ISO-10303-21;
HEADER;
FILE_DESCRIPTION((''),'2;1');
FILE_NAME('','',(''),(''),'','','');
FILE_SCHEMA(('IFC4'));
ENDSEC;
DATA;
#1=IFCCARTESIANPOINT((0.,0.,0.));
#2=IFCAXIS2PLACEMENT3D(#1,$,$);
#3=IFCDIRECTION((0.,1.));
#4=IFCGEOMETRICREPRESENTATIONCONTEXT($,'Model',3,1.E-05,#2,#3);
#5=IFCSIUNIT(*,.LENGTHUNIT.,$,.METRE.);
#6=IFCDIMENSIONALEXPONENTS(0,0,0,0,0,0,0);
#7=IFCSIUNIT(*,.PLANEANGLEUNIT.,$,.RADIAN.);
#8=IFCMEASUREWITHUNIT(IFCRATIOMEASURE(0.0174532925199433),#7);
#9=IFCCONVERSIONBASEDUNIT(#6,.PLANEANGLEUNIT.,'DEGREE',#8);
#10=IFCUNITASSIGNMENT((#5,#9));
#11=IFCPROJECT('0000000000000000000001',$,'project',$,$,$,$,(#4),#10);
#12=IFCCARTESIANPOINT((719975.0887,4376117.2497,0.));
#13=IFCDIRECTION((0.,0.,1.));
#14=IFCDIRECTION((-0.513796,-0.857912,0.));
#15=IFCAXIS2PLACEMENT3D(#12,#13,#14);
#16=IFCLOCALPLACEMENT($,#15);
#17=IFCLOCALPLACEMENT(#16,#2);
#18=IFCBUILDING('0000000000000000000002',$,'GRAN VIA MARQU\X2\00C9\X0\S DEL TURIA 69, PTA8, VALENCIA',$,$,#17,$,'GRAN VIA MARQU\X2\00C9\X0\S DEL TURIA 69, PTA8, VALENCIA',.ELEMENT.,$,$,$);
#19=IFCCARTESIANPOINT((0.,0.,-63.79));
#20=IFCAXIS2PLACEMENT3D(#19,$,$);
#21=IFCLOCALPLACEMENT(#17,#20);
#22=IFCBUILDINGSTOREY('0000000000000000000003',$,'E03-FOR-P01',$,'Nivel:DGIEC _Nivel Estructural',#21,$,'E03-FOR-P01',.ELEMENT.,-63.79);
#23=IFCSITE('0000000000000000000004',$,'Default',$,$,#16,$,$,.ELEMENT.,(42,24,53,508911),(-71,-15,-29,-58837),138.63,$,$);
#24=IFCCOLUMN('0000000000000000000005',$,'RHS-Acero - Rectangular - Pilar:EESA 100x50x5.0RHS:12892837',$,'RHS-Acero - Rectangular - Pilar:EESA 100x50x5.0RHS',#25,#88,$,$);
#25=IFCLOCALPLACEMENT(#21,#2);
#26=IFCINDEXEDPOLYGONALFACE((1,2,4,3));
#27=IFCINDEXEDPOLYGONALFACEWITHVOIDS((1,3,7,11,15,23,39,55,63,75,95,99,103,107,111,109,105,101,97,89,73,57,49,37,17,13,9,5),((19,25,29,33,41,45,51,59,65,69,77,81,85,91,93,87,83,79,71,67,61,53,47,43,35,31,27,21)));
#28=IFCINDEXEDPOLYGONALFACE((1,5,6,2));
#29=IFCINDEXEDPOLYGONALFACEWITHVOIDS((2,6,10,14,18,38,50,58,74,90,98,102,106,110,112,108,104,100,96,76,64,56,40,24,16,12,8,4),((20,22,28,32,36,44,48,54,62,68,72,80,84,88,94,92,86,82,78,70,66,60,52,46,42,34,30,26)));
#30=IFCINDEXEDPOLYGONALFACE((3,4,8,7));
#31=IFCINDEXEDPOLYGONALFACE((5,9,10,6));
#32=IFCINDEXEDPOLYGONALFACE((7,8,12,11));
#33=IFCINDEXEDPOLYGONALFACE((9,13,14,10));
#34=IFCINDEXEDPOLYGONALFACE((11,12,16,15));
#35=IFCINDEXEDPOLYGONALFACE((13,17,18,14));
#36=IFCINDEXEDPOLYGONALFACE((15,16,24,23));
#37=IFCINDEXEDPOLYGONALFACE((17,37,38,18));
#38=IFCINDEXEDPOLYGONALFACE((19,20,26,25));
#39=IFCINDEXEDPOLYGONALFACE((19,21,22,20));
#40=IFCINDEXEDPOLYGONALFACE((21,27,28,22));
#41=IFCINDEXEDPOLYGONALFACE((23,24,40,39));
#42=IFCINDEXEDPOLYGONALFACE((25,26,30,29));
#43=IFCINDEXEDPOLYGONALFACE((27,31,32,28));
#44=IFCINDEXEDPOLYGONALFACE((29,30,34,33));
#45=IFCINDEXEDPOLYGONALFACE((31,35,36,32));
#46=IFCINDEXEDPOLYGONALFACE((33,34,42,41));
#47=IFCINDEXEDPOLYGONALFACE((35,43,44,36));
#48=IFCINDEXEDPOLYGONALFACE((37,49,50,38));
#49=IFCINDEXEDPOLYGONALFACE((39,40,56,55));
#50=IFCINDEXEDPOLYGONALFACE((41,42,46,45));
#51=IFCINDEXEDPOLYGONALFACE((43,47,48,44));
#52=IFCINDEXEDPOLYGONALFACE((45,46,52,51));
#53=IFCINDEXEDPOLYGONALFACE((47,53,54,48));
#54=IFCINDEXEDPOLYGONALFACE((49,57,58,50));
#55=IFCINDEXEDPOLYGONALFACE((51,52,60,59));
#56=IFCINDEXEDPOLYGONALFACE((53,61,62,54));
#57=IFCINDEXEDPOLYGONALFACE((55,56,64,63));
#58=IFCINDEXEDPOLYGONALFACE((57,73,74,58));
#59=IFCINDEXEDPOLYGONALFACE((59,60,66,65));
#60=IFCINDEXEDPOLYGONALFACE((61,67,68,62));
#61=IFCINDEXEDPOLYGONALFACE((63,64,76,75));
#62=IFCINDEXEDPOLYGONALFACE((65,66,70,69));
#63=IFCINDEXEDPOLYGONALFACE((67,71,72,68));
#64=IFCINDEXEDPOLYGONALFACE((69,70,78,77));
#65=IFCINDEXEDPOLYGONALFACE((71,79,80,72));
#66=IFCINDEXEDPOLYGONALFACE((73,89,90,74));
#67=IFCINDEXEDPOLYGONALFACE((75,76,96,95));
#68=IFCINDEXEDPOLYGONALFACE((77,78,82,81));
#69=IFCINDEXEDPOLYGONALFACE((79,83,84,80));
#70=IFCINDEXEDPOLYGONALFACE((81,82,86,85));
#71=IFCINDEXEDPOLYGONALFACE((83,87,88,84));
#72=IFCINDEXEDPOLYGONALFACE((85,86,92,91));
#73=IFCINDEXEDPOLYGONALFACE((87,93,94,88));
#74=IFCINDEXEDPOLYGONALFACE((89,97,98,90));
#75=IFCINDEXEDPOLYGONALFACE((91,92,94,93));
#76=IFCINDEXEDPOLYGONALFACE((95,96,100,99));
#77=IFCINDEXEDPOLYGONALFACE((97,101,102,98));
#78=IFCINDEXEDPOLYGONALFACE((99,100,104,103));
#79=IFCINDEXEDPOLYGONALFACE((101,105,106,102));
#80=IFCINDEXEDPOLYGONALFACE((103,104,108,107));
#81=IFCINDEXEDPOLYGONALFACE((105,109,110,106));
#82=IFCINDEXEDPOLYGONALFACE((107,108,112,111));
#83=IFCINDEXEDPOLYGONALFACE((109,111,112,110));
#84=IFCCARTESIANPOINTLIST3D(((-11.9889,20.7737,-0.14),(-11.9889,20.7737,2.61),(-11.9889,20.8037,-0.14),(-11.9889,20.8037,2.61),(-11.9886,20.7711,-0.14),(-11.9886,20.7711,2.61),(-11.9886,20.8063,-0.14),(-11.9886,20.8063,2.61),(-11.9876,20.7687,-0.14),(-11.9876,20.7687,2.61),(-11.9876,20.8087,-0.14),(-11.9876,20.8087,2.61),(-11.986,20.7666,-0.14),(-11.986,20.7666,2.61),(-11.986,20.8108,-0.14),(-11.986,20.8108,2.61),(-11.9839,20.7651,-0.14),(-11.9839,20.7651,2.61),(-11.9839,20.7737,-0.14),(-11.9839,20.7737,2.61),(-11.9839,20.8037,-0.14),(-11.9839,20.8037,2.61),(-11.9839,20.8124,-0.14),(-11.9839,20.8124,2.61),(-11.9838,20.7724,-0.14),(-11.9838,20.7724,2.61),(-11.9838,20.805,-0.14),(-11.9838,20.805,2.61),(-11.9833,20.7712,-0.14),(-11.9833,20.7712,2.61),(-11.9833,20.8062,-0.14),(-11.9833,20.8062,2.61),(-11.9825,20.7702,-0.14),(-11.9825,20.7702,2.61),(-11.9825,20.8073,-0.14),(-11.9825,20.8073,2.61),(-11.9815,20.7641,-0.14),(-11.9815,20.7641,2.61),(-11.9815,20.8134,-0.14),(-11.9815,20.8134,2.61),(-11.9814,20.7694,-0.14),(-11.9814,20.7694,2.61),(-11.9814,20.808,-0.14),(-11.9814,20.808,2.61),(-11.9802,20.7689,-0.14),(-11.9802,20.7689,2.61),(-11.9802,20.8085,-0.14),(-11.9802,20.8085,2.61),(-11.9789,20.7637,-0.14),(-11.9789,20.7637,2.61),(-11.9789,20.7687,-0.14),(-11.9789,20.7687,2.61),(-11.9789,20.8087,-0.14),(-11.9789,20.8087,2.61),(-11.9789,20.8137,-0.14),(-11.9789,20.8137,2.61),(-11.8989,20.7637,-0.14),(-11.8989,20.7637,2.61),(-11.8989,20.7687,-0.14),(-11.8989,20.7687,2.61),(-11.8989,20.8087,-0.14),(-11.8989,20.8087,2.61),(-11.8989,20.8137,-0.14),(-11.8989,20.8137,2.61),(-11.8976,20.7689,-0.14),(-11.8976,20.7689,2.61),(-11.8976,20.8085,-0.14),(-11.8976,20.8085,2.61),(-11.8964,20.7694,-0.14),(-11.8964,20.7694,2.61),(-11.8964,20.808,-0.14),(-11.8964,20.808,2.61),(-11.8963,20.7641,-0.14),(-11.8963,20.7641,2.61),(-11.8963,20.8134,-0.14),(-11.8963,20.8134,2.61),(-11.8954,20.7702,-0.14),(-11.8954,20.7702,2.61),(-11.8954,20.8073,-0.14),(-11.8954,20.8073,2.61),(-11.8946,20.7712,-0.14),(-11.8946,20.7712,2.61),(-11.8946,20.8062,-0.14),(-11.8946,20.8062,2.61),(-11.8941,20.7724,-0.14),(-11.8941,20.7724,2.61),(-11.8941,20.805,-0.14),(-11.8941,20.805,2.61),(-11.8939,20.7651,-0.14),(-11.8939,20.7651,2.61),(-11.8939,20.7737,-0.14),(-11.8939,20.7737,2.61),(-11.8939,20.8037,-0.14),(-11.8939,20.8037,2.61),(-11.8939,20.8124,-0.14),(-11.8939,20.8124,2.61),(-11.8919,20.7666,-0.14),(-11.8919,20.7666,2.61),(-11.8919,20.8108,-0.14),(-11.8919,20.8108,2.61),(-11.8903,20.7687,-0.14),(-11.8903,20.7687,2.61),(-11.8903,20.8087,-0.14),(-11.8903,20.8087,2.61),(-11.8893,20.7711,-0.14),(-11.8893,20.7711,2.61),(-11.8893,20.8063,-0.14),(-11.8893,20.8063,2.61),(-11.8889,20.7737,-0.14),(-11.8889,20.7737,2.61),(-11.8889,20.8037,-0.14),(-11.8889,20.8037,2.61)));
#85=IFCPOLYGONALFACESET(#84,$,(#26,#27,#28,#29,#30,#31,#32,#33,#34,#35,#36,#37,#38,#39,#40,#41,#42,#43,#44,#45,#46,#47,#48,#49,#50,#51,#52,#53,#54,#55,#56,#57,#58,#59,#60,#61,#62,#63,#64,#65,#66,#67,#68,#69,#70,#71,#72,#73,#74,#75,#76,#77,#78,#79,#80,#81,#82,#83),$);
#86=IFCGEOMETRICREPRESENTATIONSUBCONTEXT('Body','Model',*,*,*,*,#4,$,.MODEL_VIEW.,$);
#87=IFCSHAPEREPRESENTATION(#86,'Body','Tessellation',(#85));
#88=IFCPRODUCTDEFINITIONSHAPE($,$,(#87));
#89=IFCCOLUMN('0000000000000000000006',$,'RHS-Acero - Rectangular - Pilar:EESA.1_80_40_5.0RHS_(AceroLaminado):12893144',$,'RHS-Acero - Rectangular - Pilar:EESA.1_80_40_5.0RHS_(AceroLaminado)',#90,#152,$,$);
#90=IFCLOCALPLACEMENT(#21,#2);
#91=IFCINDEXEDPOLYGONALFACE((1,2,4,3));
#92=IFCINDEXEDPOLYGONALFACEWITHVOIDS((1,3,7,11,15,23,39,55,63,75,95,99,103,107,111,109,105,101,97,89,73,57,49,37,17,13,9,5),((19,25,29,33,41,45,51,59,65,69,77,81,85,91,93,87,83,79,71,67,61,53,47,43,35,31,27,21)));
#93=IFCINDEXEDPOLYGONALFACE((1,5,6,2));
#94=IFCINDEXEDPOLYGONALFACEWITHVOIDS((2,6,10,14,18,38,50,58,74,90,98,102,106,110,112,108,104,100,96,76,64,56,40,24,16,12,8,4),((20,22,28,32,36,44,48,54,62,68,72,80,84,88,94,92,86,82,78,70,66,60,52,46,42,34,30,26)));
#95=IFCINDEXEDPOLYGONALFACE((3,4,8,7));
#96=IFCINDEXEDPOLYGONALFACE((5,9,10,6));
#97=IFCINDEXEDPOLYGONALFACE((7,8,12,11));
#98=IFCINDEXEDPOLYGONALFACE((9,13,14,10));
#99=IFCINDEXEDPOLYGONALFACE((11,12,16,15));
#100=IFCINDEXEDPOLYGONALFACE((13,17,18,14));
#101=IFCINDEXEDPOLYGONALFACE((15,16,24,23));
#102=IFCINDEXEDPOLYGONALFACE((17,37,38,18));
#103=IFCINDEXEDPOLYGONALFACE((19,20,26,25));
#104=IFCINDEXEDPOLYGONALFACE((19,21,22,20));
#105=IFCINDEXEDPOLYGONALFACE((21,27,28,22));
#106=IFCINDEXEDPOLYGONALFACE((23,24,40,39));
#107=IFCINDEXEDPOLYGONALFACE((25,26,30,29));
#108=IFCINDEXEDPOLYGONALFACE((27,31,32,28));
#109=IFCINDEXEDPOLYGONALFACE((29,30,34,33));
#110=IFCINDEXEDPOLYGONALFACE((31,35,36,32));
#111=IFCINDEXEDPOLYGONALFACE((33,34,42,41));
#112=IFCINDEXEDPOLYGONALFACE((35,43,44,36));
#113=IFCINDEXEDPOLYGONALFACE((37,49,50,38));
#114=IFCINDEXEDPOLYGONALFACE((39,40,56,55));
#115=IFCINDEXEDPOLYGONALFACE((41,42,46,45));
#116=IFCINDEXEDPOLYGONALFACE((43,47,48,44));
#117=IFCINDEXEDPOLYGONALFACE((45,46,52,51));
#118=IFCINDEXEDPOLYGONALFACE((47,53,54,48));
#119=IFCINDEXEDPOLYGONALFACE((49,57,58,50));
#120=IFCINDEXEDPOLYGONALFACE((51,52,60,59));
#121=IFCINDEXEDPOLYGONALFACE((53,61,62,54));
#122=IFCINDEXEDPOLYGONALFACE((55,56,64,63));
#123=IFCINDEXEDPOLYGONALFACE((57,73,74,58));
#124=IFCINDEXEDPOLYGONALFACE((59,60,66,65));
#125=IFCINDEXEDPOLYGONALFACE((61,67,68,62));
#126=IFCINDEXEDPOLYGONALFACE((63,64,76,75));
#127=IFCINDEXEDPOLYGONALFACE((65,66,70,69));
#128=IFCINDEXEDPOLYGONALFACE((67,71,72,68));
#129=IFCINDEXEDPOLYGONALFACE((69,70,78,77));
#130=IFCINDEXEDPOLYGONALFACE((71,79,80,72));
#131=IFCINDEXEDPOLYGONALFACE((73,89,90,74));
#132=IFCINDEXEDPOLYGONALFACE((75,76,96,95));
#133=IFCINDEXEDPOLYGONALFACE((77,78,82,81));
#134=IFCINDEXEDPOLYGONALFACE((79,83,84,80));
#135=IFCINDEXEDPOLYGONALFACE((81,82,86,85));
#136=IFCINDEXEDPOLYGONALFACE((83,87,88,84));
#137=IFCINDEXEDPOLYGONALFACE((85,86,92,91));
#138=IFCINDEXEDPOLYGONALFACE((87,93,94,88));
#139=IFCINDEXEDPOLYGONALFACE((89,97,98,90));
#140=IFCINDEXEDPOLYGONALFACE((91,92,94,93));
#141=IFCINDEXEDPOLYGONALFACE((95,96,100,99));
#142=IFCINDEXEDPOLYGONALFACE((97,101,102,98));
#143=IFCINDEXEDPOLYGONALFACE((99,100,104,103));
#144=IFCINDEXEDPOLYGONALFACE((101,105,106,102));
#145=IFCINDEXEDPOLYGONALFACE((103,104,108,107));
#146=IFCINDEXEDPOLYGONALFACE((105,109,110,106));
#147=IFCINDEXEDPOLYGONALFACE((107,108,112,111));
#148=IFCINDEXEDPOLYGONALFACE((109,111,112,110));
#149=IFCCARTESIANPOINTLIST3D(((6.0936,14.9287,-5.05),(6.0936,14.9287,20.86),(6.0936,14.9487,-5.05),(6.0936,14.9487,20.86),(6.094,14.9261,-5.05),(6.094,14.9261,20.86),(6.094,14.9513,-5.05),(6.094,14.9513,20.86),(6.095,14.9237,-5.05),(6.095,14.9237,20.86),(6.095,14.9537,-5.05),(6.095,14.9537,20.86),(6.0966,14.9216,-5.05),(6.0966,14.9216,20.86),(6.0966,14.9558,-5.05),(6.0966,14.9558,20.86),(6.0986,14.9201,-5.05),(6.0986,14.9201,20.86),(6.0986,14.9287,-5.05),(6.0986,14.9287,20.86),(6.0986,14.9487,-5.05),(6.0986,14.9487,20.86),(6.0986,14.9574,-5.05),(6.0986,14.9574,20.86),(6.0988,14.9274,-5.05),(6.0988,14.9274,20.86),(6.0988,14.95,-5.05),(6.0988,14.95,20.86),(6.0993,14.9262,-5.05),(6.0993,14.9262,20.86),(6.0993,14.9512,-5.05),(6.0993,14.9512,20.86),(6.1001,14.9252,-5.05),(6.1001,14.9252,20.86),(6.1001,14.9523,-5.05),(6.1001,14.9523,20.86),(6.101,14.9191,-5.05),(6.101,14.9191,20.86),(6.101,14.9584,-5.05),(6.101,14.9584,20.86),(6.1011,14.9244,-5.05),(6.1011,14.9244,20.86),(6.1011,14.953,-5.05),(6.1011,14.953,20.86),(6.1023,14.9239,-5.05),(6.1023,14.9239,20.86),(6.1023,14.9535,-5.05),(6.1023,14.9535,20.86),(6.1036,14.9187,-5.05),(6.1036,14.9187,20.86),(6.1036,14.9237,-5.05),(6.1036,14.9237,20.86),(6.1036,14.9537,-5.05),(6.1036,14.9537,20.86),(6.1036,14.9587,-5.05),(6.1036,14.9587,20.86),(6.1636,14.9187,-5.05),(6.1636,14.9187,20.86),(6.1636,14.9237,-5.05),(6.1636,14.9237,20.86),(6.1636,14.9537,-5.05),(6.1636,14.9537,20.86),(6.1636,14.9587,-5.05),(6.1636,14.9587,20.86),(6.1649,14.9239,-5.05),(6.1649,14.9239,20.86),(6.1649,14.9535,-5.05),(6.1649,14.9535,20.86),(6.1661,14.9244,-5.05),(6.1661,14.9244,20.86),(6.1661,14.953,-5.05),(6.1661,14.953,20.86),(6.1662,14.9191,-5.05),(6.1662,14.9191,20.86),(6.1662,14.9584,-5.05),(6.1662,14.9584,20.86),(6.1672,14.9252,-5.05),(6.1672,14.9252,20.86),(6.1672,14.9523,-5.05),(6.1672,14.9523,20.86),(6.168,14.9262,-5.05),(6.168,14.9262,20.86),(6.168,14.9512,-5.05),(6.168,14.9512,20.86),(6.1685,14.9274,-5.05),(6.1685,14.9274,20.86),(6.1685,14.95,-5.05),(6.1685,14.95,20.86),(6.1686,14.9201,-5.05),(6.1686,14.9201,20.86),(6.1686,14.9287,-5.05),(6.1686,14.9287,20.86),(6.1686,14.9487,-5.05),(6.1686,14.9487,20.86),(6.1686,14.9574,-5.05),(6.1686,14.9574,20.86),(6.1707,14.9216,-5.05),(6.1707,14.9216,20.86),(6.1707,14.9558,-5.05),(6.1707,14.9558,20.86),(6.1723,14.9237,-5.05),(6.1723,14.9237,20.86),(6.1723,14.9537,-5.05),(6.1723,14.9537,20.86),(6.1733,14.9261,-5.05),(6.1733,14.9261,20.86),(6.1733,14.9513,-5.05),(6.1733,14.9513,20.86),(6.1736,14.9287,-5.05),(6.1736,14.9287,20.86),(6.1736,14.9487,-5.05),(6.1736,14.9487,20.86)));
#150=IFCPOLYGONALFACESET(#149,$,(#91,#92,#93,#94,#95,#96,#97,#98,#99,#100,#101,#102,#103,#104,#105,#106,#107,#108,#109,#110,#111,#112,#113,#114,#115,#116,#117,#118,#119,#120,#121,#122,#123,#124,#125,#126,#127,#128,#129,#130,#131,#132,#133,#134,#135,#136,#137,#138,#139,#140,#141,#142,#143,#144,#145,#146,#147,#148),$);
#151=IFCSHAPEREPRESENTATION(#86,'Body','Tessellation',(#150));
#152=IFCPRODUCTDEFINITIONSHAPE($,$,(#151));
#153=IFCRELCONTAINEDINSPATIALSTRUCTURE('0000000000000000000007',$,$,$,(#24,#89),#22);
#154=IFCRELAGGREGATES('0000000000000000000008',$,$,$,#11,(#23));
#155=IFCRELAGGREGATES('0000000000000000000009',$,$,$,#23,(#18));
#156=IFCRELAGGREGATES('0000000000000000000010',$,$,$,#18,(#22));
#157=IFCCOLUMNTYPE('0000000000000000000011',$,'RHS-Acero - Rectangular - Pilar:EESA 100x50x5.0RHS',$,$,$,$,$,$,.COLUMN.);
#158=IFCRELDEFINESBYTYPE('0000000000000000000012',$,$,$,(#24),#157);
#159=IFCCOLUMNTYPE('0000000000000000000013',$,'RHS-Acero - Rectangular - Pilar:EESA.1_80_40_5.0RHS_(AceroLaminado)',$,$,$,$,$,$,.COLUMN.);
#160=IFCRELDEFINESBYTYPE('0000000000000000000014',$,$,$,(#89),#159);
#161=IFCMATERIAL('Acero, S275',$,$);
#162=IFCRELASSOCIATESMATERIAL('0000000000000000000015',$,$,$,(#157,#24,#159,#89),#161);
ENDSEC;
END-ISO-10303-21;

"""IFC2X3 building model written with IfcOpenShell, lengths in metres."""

from ifc_helpers import new_model, entity, si_unit, converted_unit, direction, frame, frame_2d, origin, place, context, subcontext, project, spatial, polyline, circle_curve, parameter, trimmed, segment, composite_curve, outline, extrude, source, transform, mapped, material, type_object, type_shapes, element, save


model = new_model("IFC2X3")

# Units and contexts
model_context = context("Model", 3, precision=1e-05, world=origin(), true_north=direction((0.0, 1.0)))
body_context = subcontext(model_context, "Body", "Model", "MODEL_VIEW")
ifc_project = project(units=[si_unit("LENGTHUNIT", "METRE"), converted_unit("PLANEANGLEUNIT", "DEGREE", entity("IfcRatioMeasure", 0.0174532925199433), si_unit("PLANEANGLEUNIT", "RADIAN"), dimensions=[0, 0, 0, 0, 0, 0, 0])], contexts=[model_context])

# Site, building, storey
site_placement = place(None, frame((719975.0887, 4376117.2497, 0.0), z_axis=(0.0, 0.0, 1.0), x_axis=(-0.513796, -0.857912, 0.0)))
site = spatial("IfcSite", under=ifc_project, at=site_placement, Name="Default", CompositionType="ELEMENT", RefLatitude=(42, 24, 53, 508911), RefLongitude=(-71, -15, -29, -58837), RefElevation=138.63)
building_placement = place(site_placement, origin())
building = spatial("IfcBuilding", under=site, at=building_placement, Name="GRAN VIA MARQUÉS DEL TURIA 69, PTA8, VALENCIA", LongName="GRAN VIA MARQUÉS DEL TURIA 69, PTA8, VALENCIA", CompositionType="ELEMENT")
storey_placement = place(building_placement, frame((0.0, 0.0, -63.79)))
storey = spatial("IfcBuildingStorey", under=building, at=storey_placement, Name="E03-FOR-P01", ObjectType="Nivel:DGIEC _Nivel Estructural", LongName="E03-FOR-P01", CompositionType="ELEMENT", Elevation=-63.79)

# Columns
ifc_material_1 = material(Name="Acero, S275")
column_type_1 = type_object("IfcColumnType", Name="RHS-Acero - Rectangular - Pilar:EESA 100x50x5.0RHS", PredefinedType="COLUMN", material=ifc_material_1)
shared_shape_1 = source(origin(), body_context, "Body", "SweptSolid", [
    extrude(outline(composite_curve([segment(polyline([(-0.015, -0.05), (0.015, -0.05)]), True, "CONTINUOUS"), segment(trimmed(circle_curve(frame_2d((0.015, -0.04), x_axis=(-1.0, 0.0)), 0.01), [parameter(90.0)], [parameter(180.0)], True, "PARAMETER"), True, "CONTINUOUS"), segment(polyline([(0.025, -0.04), (0.025, 0.04)]), True, "CONTINUOUS"), segment(trimmed(circle_curve(frame_2d((0.015, 0.04), x_axis=(-1.0, 0.0)), 0.01), [parameter(180.0)], [parameter(270.0)], True, "PARAMETER"), True, "CONTINUOUS"), segment(polyline([(0.015, 0.05), (-0.015, 0.05)]), True, "CONTINUOUS"), segment(trimmed(circle_curve(frame_2d((-0.015, 0.04), x_axis=(-1.0, 0.0)), 0.01), [parameter(270.0)], [parameter(360.0)], True, "PARAMETER"), True, "CONTINUOUS"), segment(polyline([(-0.025, 0.04), (-0.025, -0.04)]), True, "CONTINUOUS"), segment(trimmed(circle_curve(frame_2d((-0.015, -0.04), x_axis=(-1.0, 0.0)), 0.01), [parameter(360.0)], [parameter(90.0)], True, "PARAMETER"), True, "CONTINUOUS")], self_intersect=False), holes=[composite_curve([segment(trimmed(circle_curve(frame_2d((-0.015, -0.04), x_axis=(-1.0, 0.0)), 0.005), [parameter(0.0)], [parameter(90.0)], True, "PARAMETER"), False, "CONTINUOUS"), segment(polyline([(-0.02, -0.04), (-0.02, 0.04)]), True, "CONTINUOUS"), segment(trimmed(circle_curve(frame_2d((-0.015, 0.04), x_axis=(-1.0, 0.0)), 0.005), [parameter(270.0)], [parameter(0.0)], True, "PARAMETER"), False, "CONTINUOUS"), segment(polyline([(-0.015, 0.045), (0.015, 0.045)]), True, "CONTINUOUS"), segment(trimmed(circle_curve(frame_2d((0.015, 0.04), x_axis=(-1.0, 0.0)), 0.005), [parameter(180.0)], [parameter(270.0)], True, "PARAMETER"), False, "CONTINUOUS"), segment(polyline([(0.02, 0.04), (0.02, -0.04)]), True, "CONTINUOUS"), segment(trimmed(circle_curve(frame_2d((0.015, -0.04), x_axis=(-1.0, 0.0)), 0.005), [parameter(90.0)], [parameter(180.0)], True, "PARAMETER"), False, "CONTINUOUS"), segment(polyline([(0.015, -0.045), (-0.015, -0.045)]), True, "CONTINUOUS")], self_intersect=False)]), frame((0.0, 0.0, -63.93), z_axis=(0.0, 0.0, 1.0), x_axis=(-1.0, 0.0, 0.0)), (0.0, 0.0, 1.0), 2.75),
])
type_shapes(column_type_1, [shared_shape_1])
column_1_placement = place(storey_placement, frame((-11.9389, 20.7887, 63.79), z_axis=(0.0, 0.0, 1.0), x_axis=(0.0, 1.0, 0.0)))
element("IfcColumn", 1, at=column_1_placement, inside=storey, type_object=column_type_1, material=ifc_material_1, Name="RHS-Acero - Rectangular - Pilar:EESA 100x50x5.0RHS:12892837", ObjectType="RHS-Acero - Rectangular - Pilar:EESA 100x50x5.0RHS", context=body_context, shape_type="MappedRepresentation", body=[
    mapped(shared_shape_1, transform((0.0, 0.0, 0.0), scale=1.0)),
])
column_type_2 = type_object("IfcColumnType", Name="RHS-Acero - Rectangular - Pilar:EESA.1_80_40_5.0RHS_(AceroLaminado)", PredefinedType="COLUMN", material=ifc_material_1)
shared_shape_2 = source(origin(), body_context, "Body", "SweptSolid", [
    extrude(outline(composite_curve([segment(polyline([(-0.01, -0.04), (0.01, -0.04)]), True, "CONTINUOUS"), segment(trimmed(circle_curve(frame_2d((0.01, -0.03), x_axis=(-1.0, 0.0)), 0.01), [parameter(90.0)], [parameter(180.0)], True, "PARAMETER"), True, "CONTINUOUS"), segment(polyline([(0.02, -0.03), (0.02, 0.03)]), True, "CONTINUOUS"), segment(trimmed(circle_curve(frame_2d((0.01, 0.03), x_axis=(-1.0, 0.0)), 0.01), [parameter(180.0)], [parameter(270.0)], True, "PARAMETER"), True, "CONTINUOUS"), segment(polyline([(0.01, 0.04), (-0.01, 0.04)]), True, "CONTINUOUS"), segment(trimmed(circle_curve(frame_2d((-0.01, 0.03), x_axis=(-1.0, 0.0)), 0.01), [parameter(270.0)], [parameter(360.0)], True, "PARAMETER"), True, "CONTINUOUS"), segment(polyline([(-0.02, 0.03), (-0.02, -0.03)]), True, "CONTINUOUS"), segment(trimmed(circle_curve(frame_2d((-0.01, -0.03), x_axis=(-1.0, 0.0)), 0.01), [parameter(360.0)], [parameter(90.0)], True, "PARAMETER"), True, "CONTINUOUS")], self_intersect=False), holes=[composite_curve([segment(trimmed(circle_curve(frame_2d((-0.01, -0.03), x_axis=(-1.0, 0.0)), 0.005), [parameter(0.0)], [parameter(90.0)], True, "PARAMETER"), False, "CONTINUOUS"), segment(polyline([(-0.015, -0.03), (-0.015, 0.03)]), True, "CONTINUOUS"), segment(trimmed(circle_curve(frame_2d((-0.01, 0.03), x_axis=(-1.0, 0.0)), 0.005), [parameter(270.0)], [parameter(0.0)], True, "PARAMETER"), False, "CONTINUOUS"), segment(polyline([(-0.01, 0.035), (0.01, 0.035)]), True, "CONTINUOUS"), segment(trimmed(circle_curve(frame_2d((0.01, 0.03), x_axis=(-1.0, 0.0)), 0.005), [parameter(180.0)], [parameter(270.0)], True, "PARAMETER"), False, "CONTINUOUS"), segment(polyline([(0.015, 0.03), (0.015, -0.03)]), True, "CONTINUOUS"), segment(trimmed(circle_curve(frame_2d((0.01, -0.03), x_axis=(-1.0, 0.0)), 0.005), [parameter(90.0)], [parameter(180.0)], True, "PARAMETER"), False, "CONTINUOUS"), segment(polyline([(0.01, -0.035), (-0.01, -0.035)]), True, "CONTINUOUS")], self_intersect=False)]), frame((0.0, 0.0, -68.84), z_axis=(0.0, 0.0, 1.0), x_axis=(-1.0, 0.0, 0.0)), (0.0, 0.0, 1.0), 25.91),
])
type_shapes(column_type_2, [shared_shape_2])
for number, where, z_axis, x_axis, name in (
    (2, (6.1336, 14.9387, 63.79), (0.0, 0.0, 1.0), (0.0, 1.0, 0.0), "RHS-Acero - Rectangular - Pilar:EESA.1_80_40_5.0RHS_(AceroLaminado):12893144"),
):
    element("IfcColumn", number, at=place(storey_placement, frame(where, z_axis=z_axis, x_axis=x_axis)), inside=storey, type_object=column_type_2, material=ifc_material_1, Name=name, ObjectType="RHS-Acero - Rectangular - Pilar:EESA.1_80_40_5.0RHS_(AceroLaminado)", context=body_context, shape_type="MappedRepresentation", body=[
        mapped(shared_shape_2, transform((0.0, 0.0, 0.0), scale=1.0)),
    ])

save(model, "model.ifc")
